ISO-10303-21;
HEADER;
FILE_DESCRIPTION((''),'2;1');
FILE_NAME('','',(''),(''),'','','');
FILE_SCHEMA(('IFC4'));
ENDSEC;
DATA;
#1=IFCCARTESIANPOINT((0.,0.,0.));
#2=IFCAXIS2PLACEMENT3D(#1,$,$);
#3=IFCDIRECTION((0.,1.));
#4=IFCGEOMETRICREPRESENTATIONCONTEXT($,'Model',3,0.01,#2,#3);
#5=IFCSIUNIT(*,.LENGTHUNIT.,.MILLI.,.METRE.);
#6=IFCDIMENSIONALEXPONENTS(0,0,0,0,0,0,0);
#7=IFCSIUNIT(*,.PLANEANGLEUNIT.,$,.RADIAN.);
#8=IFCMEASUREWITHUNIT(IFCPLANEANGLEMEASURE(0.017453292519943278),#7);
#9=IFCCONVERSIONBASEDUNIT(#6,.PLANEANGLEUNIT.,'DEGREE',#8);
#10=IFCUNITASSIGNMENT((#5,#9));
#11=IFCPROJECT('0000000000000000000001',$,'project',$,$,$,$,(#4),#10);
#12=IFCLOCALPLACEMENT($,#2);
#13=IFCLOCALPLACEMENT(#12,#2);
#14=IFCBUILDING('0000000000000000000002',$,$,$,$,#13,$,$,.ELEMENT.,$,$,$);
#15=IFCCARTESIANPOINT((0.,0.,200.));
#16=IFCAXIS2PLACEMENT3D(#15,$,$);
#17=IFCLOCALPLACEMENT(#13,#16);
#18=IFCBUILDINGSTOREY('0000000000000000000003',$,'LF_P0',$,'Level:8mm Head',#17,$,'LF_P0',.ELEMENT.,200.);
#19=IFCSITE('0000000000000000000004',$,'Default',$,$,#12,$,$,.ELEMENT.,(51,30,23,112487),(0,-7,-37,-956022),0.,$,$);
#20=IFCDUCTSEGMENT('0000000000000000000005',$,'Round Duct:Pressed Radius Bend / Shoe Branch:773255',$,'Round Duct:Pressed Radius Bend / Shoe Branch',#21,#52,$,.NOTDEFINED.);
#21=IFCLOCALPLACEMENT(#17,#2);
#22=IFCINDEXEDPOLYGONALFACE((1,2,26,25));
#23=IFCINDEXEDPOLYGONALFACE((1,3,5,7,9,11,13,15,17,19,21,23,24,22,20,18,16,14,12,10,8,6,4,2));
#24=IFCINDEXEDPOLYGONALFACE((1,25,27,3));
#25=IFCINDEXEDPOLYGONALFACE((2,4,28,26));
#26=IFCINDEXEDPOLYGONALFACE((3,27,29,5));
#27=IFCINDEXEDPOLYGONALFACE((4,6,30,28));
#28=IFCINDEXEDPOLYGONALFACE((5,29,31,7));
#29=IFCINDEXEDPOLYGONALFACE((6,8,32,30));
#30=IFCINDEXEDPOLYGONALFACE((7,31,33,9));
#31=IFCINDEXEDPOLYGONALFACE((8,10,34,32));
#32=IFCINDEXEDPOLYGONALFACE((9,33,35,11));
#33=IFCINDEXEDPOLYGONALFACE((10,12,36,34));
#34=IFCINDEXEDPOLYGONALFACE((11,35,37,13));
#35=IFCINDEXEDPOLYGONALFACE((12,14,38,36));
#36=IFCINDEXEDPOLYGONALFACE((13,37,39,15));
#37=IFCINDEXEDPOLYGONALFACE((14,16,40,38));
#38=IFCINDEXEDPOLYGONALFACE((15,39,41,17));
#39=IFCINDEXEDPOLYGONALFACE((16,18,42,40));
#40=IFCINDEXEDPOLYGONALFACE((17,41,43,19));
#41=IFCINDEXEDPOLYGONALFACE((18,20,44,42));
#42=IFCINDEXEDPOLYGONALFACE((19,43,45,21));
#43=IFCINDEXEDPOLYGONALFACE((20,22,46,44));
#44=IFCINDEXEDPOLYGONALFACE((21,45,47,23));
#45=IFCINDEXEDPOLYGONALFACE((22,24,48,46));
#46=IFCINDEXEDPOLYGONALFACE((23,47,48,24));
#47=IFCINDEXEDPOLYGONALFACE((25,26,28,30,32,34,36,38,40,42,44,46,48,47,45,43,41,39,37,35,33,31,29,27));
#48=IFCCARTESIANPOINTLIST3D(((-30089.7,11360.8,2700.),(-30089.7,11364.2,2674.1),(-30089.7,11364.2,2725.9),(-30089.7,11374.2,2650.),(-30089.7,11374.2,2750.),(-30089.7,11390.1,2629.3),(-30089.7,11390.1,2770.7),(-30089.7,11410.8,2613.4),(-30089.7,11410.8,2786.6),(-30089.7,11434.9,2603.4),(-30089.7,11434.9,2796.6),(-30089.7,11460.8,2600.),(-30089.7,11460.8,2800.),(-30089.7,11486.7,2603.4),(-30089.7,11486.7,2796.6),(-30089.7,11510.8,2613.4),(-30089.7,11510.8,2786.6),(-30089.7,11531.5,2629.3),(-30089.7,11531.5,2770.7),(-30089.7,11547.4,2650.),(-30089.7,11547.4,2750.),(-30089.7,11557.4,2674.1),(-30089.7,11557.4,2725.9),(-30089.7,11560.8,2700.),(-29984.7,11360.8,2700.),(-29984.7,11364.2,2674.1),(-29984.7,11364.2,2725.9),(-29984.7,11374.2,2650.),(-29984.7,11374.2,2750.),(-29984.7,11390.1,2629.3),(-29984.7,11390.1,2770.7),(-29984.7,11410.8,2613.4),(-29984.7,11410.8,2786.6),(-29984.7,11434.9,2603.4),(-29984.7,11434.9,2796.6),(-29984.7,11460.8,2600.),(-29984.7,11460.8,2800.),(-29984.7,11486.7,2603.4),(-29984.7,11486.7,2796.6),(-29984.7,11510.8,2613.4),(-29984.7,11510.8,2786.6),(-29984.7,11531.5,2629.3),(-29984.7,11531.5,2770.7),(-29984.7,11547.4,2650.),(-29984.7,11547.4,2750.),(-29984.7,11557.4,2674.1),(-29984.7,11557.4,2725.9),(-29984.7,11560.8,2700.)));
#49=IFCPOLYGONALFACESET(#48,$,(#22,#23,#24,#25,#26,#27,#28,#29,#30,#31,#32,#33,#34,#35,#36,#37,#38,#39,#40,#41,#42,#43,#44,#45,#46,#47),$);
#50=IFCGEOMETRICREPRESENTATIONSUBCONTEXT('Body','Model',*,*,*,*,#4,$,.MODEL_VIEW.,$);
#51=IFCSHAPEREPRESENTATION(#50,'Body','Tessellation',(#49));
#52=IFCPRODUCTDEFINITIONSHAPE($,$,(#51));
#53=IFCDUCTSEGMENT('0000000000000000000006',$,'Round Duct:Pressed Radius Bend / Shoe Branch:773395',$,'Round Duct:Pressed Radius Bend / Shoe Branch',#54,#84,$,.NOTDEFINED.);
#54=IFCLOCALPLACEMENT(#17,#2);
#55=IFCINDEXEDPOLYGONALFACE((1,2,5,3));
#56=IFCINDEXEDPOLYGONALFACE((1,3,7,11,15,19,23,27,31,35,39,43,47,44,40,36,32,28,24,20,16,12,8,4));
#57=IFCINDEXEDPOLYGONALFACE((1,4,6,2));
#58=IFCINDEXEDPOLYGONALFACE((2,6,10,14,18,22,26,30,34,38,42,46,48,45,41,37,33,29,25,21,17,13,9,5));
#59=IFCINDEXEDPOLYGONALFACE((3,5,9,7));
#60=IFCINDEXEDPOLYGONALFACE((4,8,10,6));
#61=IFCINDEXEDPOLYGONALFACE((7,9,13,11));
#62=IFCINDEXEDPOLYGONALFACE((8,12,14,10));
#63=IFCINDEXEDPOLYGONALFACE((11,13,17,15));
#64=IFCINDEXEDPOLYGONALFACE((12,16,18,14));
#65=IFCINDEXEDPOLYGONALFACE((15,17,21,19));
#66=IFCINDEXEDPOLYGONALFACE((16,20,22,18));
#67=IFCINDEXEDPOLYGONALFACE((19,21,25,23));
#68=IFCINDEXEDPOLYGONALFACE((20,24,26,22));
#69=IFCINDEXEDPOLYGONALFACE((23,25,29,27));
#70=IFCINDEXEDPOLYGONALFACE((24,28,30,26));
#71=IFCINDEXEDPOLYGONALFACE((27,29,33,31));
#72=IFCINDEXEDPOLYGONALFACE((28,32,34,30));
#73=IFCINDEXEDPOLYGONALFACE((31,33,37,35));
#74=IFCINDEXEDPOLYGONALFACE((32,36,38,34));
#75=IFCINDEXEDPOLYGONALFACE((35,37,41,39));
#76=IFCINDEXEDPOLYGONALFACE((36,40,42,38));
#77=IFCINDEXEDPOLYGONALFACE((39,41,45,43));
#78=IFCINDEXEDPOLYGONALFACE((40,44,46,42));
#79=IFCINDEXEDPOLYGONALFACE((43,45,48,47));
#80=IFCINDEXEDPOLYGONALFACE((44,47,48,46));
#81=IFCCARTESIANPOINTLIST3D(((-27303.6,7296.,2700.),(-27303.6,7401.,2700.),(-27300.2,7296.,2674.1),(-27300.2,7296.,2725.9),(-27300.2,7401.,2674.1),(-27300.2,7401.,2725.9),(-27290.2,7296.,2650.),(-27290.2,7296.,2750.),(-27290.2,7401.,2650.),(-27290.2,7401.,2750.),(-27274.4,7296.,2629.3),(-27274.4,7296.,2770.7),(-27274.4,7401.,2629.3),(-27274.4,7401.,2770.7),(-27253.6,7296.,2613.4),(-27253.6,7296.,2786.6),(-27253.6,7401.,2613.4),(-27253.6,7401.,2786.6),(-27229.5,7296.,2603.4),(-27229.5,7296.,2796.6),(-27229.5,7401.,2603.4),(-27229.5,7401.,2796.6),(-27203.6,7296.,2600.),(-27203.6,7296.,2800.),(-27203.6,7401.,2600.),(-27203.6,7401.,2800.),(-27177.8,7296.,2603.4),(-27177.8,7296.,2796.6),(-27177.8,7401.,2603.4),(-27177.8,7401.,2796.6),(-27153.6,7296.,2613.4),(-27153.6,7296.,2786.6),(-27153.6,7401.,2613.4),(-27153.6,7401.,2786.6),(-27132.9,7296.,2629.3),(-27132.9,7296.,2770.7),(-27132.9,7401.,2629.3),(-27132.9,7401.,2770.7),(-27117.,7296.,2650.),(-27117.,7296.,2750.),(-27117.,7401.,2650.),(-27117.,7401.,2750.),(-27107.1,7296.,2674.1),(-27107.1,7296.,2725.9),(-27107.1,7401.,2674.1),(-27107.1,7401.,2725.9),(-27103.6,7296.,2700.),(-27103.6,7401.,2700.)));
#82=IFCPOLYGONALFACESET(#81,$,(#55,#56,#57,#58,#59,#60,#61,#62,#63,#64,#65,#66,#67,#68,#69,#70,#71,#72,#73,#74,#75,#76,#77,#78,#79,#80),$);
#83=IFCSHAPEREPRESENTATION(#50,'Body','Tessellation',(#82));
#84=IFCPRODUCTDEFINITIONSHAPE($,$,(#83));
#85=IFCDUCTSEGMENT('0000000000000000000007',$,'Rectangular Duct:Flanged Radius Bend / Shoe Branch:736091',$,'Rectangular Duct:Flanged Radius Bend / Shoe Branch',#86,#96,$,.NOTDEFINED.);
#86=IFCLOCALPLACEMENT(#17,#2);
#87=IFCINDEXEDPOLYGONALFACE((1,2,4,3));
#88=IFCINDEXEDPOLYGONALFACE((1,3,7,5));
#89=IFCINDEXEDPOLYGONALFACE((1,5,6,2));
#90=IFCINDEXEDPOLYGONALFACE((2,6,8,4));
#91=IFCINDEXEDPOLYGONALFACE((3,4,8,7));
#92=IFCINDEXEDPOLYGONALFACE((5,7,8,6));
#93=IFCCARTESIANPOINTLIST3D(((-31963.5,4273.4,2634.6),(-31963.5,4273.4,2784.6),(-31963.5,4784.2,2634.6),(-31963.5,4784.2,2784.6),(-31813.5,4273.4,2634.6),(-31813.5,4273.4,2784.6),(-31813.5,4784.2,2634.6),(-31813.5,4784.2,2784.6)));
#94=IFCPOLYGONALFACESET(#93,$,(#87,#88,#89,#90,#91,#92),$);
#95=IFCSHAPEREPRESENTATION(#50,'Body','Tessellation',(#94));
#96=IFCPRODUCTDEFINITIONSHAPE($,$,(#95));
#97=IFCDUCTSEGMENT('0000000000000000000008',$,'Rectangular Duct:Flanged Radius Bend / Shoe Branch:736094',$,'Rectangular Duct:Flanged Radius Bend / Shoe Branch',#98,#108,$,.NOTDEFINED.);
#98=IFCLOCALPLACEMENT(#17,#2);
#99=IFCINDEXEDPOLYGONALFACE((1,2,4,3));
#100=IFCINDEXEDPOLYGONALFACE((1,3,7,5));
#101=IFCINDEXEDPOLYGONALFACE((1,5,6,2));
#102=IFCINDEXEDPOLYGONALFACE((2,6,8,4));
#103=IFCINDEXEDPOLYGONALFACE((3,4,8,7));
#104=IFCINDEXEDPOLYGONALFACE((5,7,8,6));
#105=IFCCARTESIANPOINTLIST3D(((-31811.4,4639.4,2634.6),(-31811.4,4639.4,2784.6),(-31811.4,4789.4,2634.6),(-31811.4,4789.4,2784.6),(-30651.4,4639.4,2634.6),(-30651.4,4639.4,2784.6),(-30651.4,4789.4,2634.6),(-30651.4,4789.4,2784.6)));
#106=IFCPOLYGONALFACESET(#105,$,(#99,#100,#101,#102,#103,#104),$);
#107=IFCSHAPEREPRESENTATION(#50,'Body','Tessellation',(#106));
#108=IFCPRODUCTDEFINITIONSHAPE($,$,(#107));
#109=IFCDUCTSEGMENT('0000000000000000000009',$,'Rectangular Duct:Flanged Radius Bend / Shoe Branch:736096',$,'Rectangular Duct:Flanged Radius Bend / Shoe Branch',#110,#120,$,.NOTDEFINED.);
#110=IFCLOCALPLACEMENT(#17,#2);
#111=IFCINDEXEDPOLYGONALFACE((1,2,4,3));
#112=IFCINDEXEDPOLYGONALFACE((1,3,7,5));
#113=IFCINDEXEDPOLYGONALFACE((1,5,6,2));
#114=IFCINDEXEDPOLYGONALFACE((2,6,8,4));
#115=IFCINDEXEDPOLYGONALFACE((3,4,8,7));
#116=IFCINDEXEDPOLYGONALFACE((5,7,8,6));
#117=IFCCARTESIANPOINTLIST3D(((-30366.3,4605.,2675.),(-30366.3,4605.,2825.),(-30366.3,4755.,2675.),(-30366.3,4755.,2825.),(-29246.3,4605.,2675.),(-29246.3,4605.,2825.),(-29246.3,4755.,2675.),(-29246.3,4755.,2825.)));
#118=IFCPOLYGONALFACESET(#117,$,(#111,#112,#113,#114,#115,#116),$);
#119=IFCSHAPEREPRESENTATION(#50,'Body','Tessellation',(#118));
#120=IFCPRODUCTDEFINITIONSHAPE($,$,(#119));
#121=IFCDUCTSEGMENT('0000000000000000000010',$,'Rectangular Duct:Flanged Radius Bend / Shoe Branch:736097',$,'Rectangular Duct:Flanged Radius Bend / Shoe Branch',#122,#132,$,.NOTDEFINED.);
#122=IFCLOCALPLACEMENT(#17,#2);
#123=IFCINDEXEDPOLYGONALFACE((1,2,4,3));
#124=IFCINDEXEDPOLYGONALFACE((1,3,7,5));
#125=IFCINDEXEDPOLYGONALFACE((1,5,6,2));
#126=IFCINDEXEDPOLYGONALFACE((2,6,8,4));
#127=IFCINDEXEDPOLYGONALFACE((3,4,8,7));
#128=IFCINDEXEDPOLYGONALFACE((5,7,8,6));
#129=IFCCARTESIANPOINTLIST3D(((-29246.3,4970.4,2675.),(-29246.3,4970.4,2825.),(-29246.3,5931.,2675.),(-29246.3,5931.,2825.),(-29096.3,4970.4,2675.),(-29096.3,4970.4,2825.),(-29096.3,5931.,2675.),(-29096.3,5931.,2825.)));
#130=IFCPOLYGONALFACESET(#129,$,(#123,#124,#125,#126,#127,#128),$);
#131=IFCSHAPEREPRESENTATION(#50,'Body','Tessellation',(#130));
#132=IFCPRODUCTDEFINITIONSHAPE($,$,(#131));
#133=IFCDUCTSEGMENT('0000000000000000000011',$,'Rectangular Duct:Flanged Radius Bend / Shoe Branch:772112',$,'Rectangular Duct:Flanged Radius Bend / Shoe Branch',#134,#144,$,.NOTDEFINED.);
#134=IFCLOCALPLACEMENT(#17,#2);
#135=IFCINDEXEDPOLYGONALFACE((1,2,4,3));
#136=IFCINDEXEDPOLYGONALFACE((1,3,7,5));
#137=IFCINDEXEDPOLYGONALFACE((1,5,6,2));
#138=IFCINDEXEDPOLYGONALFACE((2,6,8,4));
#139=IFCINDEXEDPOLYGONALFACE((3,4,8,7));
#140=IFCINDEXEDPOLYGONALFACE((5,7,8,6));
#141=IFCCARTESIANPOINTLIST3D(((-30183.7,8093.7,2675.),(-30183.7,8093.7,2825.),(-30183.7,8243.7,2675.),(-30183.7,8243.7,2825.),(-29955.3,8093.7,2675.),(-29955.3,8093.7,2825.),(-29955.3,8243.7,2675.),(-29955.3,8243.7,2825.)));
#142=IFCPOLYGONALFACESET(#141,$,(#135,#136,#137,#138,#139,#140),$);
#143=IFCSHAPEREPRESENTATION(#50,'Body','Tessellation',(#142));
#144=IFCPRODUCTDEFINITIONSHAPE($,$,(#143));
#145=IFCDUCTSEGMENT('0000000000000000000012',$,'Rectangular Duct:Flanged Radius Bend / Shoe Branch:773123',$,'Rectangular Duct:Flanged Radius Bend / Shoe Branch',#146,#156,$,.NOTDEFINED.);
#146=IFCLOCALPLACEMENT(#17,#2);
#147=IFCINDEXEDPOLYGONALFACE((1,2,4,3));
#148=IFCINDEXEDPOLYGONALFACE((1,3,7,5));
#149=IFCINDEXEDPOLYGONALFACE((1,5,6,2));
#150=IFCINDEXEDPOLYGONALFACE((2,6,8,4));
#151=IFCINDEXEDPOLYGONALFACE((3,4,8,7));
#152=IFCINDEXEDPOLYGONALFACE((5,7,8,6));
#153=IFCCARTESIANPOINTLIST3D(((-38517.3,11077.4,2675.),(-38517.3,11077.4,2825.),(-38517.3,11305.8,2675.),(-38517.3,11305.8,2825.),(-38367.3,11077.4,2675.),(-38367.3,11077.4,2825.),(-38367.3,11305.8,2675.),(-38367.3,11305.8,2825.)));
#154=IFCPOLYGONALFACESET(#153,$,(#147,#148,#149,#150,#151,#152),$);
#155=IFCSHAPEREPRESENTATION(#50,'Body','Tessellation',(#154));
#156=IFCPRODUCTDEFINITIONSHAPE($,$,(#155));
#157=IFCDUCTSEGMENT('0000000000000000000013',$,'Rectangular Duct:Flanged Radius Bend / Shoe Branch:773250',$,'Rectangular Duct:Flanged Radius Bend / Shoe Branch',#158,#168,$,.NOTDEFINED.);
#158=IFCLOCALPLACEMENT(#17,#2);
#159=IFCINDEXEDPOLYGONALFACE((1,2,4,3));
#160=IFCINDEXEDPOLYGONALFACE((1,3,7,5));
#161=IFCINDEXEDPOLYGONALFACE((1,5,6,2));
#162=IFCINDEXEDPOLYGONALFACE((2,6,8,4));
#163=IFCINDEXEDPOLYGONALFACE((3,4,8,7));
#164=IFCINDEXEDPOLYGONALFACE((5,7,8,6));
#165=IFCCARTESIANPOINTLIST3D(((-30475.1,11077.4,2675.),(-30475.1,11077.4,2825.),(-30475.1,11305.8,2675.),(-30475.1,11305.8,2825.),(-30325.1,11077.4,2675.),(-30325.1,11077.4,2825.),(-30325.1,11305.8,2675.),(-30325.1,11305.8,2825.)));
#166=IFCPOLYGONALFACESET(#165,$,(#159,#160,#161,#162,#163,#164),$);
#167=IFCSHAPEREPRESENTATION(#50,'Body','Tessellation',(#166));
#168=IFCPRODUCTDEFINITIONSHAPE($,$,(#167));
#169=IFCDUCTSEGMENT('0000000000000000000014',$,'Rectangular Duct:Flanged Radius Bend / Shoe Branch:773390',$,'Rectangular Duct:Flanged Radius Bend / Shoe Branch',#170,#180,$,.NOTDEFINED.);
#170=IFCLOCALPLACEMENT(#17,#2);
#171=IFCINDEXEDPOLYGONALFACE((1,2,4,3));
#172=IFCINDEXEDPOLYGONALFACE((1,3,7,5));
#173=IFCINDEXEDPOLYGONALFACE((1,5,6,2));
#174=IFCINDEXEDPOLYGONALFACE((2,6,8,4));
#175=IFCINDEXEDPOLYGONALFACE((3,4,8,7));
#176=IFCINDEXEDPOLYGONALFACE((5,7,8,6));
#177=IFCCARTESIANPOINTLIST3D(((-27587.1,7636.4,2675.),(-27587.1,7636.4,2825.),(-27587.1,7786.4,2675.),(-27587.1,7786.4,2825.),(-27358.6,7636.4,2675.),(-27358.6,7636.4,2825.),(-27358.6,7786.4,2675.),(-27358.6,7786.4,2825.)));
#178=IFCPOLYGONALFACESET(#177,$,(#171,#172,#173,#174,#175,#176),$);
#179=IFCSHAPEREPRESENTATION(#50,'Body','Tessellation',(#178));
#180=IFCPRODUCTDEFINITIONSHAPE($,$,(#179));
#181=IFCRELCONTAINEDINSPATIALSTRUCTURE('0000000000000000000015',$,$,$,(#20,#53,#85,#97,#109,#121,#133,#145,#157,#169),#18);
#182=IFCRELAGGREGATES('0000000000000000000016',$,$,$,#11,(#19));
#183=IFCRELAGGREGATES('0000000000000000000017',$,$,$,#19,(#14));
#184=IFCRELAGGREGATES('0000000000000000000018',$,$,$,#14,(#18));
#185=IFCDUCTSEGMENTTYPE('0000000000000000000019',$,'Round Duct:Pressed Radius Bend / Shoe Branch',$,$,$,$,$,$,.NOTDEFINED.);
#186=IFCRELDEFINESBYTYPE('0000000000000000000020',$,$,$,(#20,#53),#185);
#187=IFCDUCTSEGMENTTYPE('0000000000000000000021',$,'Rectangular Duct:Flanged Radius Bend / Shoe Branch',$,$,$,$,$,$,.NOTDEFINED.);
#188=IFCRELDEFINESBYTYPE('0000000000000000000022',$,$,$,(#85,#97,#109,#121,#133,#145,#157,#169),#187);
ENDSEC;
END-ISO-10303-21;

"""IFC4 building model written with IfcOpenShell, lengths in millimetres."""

from ifc_helpers import new_model, entity, si_unit, converted_unit, direction, frame, origin, place, context, subcontext, project, spatial, arc, indexed_curve, outline, extrude, type_object, element, save


model = new_model("IFC4")

# Units and contexts
model_context = context("Model", 3, precision=0.01, world=origin(), true_north=direction((0.0, 1.0)))
body_context = subcontext(model_context, "Body", "Model", "MODEL_VIEW")
ifc_project = project(units=[si_unit("LENGTHUNIT", "METRE", prefix="MILLI"), converted_unit("PLANEANGLEUNIT", "DEGREE", entity("IfcPlaneAngleMeasure", 0.017453292519943278), si_unit("PLANEANGLEUNIT", "RADIAN"), dimensions=[0, 0, 0, 0, 0, 0, 0])], contexts=[model_context])

# Site, building, storey
site_placement = place(None, origin())
site = spatial("IfcSite", under=ifc_project, at=site_placement, Name="Default", CompositionType="ELEMENT", RefLatitude=(51, 30, 23, 112487), RefLongitude=(0, -7, -37, -956022), RefElevation=0.0)
building_placement = place(site_placement, origin())
building = spatial("IfcBuilding", under=site, at=building_placement, CompositionType="ELEMENT")
storey_placement = place(building_placement, frame((0.0, 0.0, 200.0)))
storey = spatial("IfcBuildingStorey", under=building, at=storey_placement, Name="LF_P0", ObjectType="Level:8mm Head", LongName="LF_P0", CompositionType="ELEMENT", Elevation=200.0)

# Duct segments
duct_segment_type_1 = type_object("IfcDuctSegmentType", Name="Round Duct:Pressed Radius Bend / Shoe Branch", PredefinedType="NOTDEFINED")
duct_segment_1_placement = place(storey_placement, origin())
element("IfcDuctSegment", 1, at=duct_segment_1_placement, inside=storey, type_object=duct_segment_type_1, Name="Round Duct:Pressed Radius Bend / Shoe Branch:773255", ObjectType="Round Duct:Pressed Radius Bend / Shoe Branch", PredefinedType="NOTDEFINED", context=body_context, shape_type="SweptSolid", body=[
    extrude(outline(indexed_curve([(100.0, 0.0), (70.7, 70.7), (0.0, 100.0), (-70.7, 70.7), (-100.0, 0.0), (-70.7, -70.7), (0.0, -100.0), (70.7, -70.7)], segments=[arc(1, 2, 3), arc(3, 4, 5), arc(5, 6, 7), arc(7, 8, 1)], self_intersect=False)), frame((-30089.7, 11460.8, 2700.0), z_axis=(1.0, 0.0, 0.0), x_axis=(0.0, 1.0, 0.0)), (0.0, 0.0, 1.0), 105.0),
])
duct_segment_2_placement = place(storey_placement, origin())
element("IfcDuctSegment", 2, at=duct_segment_2_placement, inside=storey, type_object=duct_segment_type_1, Name="Round Duct:Pressed Radius Bend / Shoe Branch:773395", ObjectType="Round Duct:Pressed Radius Bend / Shoe Branch", PredefinedType="NOTDEFINED", context=body_context, shape_type="SweptSolid", body=[
    extrude(outline(indexed_curve([(100.0, 0.0), (70.7, 70.7), (0.0, 100.0), (-70.7, 70.7), (-100.0, 0.0), (-70.7, -70.7), (0.0, -100.0), (70.7, -70.7)], segments=[arc(1, 2, 3), arc(3, 4, 5), arc(5, 6, 7), arc(7, 8, 1)], self_intersect=False)), frame((-27203.6, 7296.0, 2700.0), z_axis=(0.0, 1.0, 0.0), x_axis=(1.0, 0.0, 0.0)), (0.0, 0.0, 1.0), 105.0),
])
duct_segment_type_2 = type_object("IfcDuctSegmentType", Name="Rectangular Duct:Flanged Radius Bend / Shoe Branch", PredefinedType="NOTDEFINED")
duct_segment_3_placement = place(storey_placement, origin())
element("IfcDuctSegment", 3, at=duct_segment_3_placement, inside=storey, type_object=duct_segment_type_2, Name="Rectangular Duct:Flanged Radius Bend / Shoe Branch:736091", ObjectType="Rectangular Duct:Flanged Radius Bend / Shoe Branch", PredefinedType="NOTDEFINED", context=body_context, shape_type="SweptSolid", body=[
    extrude(outline(indexed_curve([(-255.4, -75.0), (255.4, -75.0), (255.4, 75.0), (-255.4, 75.0), (-255.4, -75.0)], self_intersect=False)), frame((-31888.5, 4528.8, 2634.6), z_axis=(0.0, 0.0, 1.0), x_axis=(0.0, 1.0, 0.0)), (0.0, 0.0, 1.0), 150.0),
])
duct_segment_4_placement = place(storey_placement, origin())
element("IfcDuctSegment", 4, at=duct_segment_4_placement, inside=storey, type_object=duct_segment_type_2, Name="Rectangular Duct:Flanged Radius Bend / Shoe Branch:736094", ObjectType="Rectangular Duct:Flanged Radius Bend / Shoe Branch", PredefinedType="NOTDEFINED", context=body_context, shape_type="SweptSolid", body=[
    extrude(outline(indexed_curve([(-580.0, -75.0), (580.0, -75.0), (580.0, 75.0), (-580.0, 75.0), (-580.0, -75.0)], self_intersect=False)), frame((-31231.4, 4714.4, 2634.6), z_axis=(0.0, 0.0, 1.0), x_axis=(-1.0, 0.0, 0.0)), (0.0, 0.0, 1.0), 150.0),
])
duct_segment_5_placement = place(storey_placement, origin())
element("IfcDuctSegment", 5, at=duct_segment_5_placement, inside=storey, type_object=duct_segment_type_2, Name="Rectangular Duct:Flanged Radius Bend / Shoe Branch:736096", ObjectType="Rectangular Duct:Flanged Radius Bend / Shoe Branch", PredefinedType="NOTDEFINED", context=body_context, shape_type="SweptSolid", body=[
    extrude(outline(indexed_curve([(-560.0, -75.0), (560.0, -75.0), (560.0, 75.0), (-560.0, 75.0), (-560.0, -75.0)], self_intersect=False)), frame((-29806.3, 4680.0, 2675.0)), (0.0, 0.0, 1.0), 150.0),
])
duct_segment_6_placement = place(storey_placement, origin())
element("IfcDuctSegment", 6, at=duct_segment_6_placement, inside=storey, type_object=duct_segment_type_2, Name="Rectangular Duct:Flanged Radius Bend / Shoe Branch:736097", ObjectType="Rectangular Duct:Flanged Radius Bend / Shoe Branch", PredefinedType="NOTDEFINED", context=body_context, shape_type="SweptSolid", body=[
    extrude(outline(indexed_curve([(-480.3, -75.0), (480.3, -75.0), (480.3, 75.0), (-480.3, 75.0), (-480.3, -75.0)], self_intersect=False)), frame((-29171.3, 5450.7, 2675.0), z_axis=(0.0, 0.0, 1.0), x_axis=(0.0, 1.0, 0.0)), (0.0, 0.0, 1.0), 150.0),
])
duct_segment_7_placement = place(storey_placement, origin())
element("IfcDuctSegment", 7, at=duct_segment_7_placement, inside=storey, type_object=duct_segment_type_2, Name="Rectangular Duct:Flanged Radius Bend / Shoe Branch:772112", ObjectType="Rectangular Duct:Flanged Radius Bend / Shoe Branch", PredefinedType="NOTDEFINED", context=body_context, shape_type="SweptSolid", body=[
    extrude(outline(indexed_curve([(-114.2, -75.0), (114.2, -75.0), (114.2, 75.0), (-114.2, 75.0), (-114.2, -75.0)], self_intersect=False)), frame((-30069.5, 8168.7, 2675.0), z_axis=(0.0, 0.0, 1.0), x_axis=(-1.0, 0.0, 0.0)), (0.0, 0.0, 1.0), 150.0),
])
duct_segment_8_placement = place(storey_placement, origin())
element("IfcDuctSegment", 8, at=duct_segment_8_placement, inside=storey, type_object=duct_segment_type_2, Name="Rectangular Duct:Flanged Radius Bend / Shoe Branch:773123", ObjectType="Rectangular Duct:Flanged Radius Bend / Shoe Branch", PredefinedType="NOTDEFINED", context=body_context, shape_type="SweptSolid", body=[
    extrude(outline(indexed_curve([(-114.2, -75.0), (114.2, -75.0), (114.2, 75.0), (-114.2, 75.0), (-114.2, -75.0)], self_intersect=False)), frame((-38442.3, 11191.6, 2675.0), z_axis=(0.0, 0.0, 1.0), x_axis=(0.0, -1.0, 0.0)), (0.0, 0.0, 1.0), 150.0),
])
duct_segment_9_placement = place(storey_placement, origin())
element("IfcDuctSegment", 9, at=duct_segment_9_placement, inside=storey, type_object=duct_segment_type_2, Name="Rectangular Duct:Flanged Radius Bend / Shoe Branch:773250", ObjectType="Rectangular Duct:Flanged Radius Bend / Shoe Branch", PredefinedType="NOTDEFINED", context=body_context, shape_type="SweptSolid", body=[
    extrude(outline(indexed_curve([(-114.2, -75.0), (114.2, -75.0), (114.2, 75.0), (-114.2, 75.0), (-114.2, -75.0)], self_intersect=False)), frame((-30400.1, 11191.6, 2675.0), z_axis=(0.0, 0.0, 1.0), x_axis=(0.0, -1.0, 0.0)), (0.0, 0.0, 1.0), 150.0),
])
duct_segment_10_placement = place(storey_placement, origin())
element("IfcDuctSegment", 10, at=duct_segment_10_placement, inside=storey, type_object=duct_segment_type_2, Name="Rectangular Duct:Flanged Radius Bend / Shoe Branch:773390", ObjectType="Rectangular Duct:Flanged Radius Bend / Shoe Branch", PredefinedType="NOTDEFINED", context=body_context, shape_type="SweptSolid", body=[
    extrude(outline(indexed_curve([(-114.2, -75.0), (114.2, -75.0), (114.2, 75.0), (-114.2, 75.0), (-114.2, -75.0)], self_intersect=False)), frame((-27472.9, 7711.4, 2675.0), z_axis=(0.0, 0.0, 1.0), x_axis=(-1.0, 0.0, 0.0)), (0.0, 0.0, 1.0), 150.0),
])

save(model, "model.ifc")
